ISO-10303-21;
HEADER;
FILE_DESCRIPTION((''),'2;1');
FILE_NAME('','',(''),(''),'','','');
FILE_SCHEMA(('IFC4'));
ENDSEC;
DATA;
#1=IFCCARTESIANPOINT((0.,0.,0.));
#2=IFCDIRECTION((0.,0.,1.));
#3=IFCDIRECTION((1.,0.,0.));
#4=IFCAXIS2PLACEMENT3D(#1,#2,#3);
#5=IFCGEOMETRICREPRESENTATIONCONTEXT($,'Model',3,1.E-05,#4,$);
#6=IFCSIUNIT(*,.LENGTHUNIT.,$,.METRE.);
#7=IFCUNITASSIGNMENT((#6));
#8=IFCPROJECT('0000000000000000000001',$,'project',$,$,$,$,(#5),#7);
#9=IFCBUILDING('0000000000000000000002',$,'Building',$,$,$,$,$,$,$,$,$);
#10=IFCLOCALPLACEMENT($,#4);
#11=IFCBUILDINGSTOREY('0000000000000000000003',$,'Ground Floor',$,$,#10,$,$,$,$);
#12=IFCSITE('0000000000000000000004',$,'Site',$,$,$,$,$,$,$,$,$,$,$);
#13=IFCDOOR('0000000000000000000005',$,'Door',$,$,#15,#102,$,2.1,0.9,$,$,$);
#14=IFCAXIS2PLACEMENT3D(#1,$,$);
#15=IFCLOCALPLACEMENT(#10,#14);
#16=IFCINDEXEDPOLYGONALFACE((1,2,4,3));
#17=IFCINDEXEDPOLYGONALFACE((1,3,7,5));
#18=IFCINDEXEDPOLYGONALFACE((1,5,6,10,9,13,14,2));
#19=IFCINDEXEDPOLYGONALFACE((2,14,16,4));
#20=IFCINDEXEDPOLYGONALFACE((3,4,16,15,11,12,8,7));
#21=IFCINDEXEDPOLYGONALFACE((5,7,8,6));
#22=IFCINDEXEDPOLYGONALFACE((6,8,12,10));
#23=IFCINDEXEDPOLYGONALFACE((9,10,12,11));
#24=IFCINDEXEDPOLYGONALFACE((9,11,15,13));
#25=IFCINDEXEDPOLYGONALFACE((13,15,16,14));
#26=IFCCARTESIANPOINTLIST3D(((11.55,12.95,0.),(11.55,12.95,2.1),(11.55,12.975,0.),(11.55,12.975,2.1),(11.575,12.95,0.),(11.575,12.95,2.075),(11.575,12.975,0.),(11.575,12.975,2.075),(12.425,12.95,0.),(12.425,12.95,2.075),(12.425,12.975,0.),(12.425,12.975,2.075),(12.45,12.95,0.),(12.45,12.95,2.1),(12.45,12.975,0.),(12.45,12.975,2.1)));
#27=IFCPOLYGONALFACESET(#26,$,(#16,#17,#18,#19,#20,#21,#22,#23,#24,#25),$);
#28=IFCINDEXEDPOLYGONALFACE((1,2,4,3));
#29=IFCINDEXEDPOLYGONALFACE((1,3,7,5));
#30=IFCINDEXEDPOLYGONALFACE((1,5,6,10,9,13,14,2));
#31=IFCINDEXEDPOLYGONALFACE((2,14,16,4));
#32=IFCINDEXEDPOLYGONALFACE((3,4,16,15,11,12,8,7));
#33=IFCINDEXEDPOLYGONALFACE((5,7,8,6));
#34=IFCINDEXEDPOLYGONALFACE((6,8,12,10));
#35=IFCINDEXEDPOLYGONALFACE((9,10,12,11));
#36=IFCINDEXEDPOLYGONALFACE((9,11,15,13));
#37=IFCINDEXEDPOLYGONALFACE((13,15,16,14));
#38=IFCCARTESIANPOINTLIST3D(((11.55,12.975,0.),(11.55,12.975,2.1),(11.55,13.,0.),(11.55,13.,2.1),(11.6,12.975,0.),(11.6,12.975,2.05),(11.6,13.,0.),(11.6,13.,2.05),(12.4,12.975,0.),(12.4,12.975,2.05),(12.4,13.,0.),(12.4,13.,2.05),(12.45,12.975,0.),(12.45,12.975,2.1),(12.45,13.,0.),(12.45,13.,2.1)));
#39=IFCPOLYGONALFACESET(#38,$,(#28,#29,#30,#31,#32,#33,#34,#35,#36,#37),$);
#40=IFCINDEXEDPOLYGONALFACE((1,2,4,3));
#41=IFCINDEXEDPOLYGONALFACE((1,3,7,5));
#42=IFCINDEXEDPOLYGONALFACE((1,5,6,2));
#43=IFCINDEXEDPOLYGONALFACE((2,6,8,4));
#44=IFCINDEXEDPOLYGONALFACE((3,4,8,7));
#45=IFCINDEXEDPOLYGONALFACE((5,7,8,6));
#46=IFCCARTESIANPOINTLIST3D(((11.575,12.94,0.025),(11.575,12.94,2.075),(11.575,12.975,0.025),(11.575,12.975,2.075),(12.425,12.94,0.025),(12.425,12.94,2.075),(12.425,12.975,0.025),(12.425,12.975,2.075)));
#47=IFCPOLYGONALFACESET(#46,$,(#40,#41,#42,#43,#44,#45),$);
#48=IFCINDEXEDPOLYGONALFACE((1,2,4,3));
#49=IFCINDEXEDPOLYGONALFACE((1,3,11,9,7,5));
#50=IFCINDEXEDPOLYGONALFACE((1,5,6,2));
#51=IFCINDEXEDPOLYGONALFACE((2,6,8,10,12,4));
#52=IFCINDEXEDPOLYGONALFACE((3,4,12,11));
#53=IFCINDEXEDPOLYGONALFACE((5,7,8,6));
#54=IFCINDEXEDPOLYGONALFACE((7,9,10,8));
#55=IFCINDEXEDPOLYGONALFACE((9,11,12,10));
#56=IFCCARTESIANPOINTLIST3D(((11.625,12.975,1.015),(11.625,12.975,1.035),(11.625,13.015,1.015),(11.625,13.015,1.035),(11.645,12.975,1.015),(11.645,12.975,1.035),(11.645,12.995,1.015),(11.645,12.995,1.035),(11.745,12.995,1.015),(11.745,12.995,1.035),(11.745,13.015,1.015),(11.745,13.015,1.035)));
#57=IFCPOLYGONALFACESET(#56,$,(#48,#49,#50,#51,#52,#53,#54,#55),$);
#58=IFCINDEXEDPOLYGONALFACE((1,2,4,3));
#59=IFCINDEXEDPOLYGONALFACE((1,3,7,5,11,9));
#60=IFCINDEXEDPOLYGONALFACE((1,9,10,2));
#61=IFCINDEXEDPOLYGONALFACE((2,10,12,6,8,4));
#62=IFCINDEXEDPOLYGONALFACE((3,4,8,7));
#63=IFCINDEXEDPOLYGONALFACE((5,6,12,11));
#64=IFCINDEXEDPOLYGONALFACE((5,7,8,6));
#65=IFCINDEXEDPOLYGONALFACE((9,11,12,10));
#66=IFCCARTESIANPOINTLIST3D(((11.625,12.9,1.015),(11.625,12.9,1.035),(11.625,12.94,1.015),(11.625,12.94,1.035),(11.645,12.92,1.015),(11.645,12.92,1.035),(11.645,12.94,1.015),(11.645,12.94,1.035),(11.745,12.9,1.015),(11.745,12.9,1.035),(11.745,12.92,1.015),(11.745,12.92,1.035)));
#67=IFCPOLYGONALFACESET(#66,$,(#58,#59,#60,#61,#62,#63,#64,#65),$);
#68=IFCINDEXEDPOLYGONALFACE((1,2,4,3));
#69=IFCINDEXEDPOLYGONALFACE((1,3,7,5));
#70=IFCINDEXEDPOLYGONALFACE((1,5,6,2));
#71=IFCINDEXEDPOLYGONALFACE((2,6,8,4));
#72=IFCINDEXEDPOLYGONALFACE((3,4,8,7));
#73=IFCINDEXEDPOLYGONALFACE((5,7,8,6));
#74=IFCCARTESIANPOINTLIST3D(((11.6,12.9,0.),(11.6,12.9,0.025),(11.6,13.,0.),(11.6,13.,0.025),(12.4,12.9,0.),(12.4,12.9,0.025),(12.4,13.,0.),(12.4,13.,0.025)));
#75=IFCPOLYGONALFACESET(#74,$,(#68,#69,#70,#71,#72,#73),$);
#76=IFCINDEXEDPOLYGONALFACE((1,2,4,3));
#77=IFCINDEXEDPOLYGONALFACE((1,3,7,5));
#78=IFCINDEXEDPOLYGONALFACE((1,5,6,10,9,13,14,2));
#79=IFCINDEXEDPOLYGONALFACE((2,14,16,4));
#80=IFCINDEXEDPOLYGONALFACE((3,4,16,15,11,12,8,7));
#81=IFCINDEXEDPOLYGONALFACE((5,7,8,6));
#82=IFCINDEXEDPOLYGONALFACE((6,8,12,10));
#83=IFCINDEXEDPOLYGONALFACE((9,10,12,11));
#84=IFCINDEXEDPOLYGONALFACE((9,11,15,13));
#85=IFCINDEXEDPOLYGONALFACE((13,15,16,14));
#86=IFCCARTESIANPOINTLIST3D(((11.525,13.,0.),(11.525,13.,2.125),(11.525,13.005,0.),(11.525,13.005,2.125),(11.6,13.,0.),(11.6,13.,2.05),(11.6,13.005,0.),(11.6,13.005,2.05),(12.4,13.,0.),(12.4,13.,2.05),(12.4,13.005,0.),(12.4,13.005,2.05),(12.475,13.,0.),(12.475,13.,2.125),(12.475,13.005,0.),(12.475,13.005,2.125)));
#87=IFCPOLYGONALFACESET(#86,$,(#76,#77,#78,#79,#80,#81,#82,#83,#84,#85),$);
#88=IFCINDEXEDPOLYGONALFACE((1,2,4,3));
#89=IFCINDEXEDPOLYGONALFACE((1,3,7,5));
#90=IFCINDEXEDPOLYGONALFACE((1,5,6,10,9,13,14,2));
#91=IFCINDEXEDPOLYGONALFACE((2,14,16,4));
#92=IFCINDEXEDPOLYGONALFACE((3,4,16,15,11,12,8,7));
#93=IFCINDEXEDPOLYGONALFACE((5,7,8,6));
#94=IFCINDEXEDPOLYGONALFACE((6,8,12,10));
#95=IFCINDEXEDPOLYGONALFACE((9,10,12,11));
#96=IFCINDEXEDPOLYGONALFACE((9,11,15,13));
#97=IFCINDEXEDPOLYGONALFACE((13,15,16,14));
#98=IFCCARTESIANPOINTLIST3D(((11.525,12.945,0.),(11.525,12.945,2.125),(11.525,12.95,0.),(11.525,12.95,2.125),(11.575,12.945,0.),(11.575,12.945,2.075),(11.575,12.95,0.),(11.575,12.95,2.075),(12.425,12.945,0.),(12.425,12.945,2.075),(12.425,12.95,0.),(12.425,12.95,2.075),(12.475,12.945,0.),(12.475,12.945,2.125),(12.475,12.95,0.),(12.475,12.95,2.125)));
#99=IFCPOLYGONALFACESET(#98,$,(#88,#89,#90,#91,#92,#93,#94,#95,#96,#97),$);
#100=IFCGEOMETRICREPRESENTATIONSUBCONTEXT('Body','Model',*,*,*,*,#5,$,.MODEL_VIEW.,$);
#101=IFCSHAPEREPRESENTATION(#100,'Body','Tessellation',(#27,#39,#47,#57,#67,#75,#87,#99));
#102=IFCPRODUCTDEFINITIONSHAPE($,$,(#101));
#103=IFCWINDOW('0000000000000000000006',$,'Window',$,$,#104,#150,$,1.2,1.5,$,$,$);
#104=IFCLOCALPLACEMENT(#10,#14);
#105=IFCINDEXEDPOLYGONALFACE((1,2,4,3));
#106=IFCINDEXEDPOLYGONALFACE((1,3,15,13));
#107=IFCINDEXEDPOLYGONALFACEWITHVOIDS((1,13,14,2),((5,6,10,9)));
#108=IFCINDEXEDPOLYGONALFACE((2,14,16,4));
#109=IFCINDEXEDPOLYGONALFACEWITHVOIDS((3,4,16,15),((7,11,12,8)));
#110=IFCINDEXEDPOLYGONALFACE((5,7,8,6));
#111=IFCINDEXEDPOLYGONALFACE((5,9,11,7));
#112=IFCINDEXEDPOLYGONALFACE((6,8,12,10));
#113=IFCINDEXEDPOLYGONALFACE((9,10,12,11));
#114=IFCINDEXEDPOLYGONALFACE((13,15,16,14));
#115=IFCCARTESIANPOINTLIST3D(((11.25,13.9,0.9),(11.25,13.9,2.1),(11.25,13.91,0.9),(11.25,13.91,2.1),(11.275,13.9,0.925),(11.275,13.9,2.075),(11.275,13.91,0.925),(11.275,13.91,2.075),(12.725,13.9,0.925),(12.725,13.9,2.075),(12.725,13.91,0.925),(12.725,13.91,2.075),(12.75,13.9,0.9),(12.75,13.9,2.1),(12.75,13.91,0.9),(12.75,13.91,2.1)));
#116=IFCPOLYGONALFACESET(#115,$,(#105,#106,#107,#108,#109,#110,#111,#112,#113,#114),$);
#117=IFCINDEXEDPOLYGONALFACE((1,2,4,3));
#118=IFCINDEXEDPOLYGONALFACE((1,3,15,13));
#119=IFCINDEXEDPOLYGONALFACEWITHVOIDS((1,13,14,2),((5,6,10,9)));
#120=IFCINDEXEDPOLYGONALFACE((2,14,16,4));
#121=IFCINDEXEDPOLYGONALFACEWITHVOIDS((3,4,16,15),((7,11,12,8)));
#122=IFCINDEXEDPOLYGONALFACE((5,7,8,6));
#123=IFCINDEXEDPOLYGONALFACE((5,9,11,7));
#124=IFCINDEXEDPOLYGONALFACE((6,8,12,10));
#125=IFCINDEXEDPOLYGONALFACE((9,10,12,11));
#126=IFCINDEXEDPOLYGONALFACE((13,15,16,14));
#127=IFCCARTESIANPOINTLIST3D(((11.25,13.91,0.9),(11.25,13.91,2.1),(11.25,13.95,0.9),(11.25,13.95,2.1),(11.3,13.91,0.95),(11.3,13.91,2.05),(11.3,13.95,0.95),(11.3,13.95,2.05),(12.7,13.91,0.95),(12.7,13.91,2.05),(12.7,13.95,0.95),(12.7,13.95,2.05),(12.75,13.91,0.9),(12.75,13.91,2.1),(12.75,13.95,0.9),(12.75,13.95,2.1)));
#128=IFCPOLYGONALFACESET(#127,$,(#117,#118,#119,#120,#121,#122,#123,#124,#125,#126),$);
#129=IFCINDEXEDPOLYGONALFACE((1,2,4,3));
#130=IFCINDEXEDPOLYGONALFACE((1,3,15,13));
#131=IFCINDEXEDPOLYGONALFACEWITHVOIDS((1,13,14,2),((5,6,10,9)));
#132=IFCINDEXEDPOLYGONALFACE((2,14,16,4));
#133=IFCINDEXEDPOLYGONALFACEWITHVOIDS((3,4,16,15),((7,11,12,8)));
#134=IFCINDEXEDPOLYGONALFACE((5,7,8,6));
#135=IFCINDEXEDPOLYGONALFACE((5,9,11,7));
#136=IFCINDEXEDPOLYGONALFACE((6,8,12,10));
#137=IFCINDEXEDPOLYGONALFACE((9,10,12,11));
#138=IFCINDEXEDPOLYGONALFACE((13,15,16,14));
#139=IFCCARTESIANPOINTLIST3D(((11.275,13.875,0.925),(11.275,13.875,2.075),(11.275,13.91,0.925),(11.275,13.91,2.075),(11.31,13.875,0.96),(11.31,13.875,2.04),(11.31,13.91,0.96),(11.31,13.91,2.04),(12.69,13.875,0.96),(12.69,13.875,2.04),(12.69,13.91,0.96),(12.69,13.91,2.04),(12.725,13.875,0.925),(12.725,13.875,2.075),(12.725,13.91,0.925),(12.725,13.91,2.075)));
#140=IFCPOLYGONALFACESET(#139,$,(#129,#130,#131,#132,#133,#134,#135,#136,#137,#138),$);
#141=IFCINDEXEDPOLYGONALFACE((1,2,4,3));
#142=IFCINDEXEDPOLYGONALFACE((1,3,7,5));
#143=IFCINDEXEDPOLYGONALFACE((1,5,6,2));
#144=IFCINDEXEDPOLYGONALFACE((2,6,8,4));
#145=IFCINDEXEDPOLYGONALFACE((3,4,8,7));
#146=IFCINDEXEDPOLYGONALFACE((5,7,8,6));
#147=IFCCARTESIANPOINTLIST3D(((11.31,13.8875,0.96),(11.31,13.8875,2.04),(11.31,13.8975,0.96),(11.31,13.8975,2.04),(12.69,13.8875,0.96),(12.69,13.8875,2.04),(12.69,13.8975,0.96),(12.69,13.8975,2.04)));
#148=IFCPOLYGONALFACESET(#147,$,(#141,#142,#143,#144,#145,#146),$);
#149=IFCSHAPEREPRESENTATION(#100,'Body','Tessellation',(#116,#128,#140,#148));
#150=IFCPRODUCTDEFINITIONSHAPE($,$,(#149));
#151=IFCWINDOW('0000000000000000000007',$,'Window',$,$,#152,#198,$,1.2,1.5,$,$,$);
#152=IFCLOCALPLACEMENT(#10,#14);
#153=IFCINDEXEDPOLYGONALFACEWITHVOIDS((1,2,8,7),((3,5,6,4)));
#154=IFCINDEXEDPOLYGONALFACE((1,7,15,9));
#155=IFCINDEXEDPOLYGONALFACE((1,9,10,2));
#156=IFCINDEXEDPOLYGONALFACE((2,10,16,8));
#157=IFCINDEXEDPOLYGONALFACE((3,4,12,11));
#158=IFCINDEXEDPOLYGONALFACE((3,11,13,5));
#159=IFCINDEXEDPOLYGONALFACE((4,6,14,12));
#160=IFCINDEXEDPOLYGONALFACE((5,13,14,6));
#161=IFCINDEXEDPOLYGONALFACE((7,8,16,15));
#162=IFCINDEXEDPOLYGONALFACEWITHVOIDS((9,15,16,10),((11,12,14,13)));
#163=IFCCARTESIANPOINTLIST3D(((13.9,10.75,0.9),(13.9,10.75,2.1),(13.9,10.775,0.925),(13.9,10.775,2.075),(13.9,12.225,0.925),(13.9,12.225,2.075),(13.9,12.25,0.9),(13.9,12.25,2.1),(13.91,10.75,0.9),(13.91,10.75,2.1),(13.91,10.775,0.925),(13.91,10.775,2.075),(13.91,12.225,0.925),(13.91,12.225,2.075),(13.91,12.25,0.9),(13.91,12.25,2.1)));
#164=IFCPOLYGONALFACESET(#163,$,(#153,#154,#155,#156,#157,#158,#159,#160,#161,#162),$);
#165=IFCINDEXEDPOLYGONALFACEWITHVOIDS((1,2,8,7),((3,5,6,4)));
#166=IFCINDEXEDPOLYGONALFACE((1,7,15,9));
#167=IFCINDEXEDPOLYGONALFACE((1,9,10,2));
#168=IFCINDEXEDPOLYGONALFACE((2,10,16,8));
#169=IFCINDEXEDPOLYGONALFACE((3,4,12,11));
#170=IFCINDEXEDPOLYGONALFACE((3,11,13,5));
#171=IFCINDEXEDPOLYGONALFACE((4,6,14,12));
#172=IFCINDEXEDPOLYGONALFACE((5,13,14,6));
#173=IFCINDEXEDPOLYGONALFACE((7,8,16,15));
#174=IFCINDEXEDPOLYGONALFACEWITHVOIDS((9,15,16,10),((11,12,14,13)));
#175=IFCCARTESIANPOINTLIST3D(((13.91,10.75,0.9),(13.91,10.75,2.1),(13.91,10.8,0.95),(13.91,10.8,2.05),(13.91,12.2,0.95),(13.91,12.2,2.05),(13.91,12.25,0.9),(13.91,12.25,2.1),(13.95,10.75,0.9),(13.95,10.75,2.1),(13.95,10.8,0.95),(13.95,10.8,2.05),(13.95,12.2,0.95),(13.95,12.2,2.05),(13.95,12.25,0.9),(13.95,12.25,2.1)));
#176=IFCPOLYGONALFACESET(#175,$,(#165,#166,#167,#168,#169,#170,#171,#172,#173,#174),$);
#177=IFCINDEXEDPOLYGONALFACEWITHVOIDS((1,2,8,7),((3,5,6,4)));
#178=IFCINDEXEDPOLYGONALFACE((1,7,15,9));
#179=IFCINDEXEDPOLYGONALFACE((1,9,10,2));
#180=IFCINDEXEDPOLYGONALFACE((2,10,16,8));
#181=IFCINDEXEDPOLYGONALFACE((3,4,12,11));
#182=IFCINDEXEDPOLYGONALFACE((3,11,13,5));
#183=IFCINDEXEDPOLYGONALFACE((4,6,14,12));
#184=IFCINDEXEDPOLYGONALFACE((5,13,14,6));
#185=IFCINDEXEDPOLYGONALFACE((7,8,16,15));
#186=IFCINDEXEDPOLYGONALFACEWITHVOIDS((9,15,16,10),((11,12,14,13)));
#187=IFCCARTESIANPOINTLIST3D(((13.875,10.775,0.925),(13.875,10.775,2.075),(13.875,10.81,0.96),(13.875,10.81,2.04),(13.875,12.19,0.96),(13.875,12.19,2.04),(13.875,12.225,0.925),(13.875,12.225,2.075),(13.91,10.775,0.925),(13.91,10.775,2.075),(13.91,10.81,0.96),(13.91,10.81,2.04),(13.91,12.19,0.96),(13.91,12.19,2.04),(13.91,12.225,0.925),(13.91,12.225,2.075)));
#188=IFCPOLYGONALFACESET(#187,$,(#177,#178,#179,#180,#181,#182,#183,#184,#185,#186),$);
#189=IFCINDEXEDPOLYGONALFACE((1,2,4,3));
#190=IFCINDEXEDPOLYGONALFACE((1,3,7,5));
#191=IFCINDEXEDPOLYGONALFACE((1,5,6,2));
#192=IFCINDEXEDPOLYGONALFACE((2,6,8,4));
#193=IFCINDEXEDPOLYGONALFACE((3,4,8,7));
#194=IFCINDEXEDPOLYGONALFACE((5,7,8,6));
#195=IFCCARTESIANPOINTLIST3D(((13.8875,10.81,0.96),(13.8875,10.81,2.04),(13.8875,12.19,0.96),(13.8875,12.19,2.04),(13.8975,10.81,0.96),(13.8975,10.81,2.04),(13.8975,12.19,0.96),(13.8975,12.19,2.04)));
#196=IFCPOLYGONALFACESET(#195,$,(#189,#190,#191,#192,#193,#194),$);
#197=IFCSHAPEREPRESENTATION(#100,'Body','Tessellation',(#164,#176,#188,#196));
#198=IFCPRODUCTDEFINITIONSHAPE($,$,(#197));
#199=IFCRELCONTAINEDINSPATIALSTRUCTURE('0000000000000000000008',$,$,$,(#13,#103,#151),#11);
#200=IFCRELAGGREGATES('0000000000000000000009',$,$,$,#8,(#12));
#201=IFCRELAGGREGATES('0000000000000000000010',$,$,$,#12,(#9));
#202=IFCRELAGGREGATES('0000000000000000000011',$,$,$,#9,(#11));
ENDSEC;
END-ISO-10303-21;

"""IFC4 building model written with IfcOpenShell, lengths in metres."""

from ifc_helpers import new_model, si_unit, frame, origin_with_axes, place, context, subcontext, project, spatial, line, indexed_curve, outline, extrude, element, save


model = new_model("IFC4")

# Units and contexts
model_context = context("Model", 3, precision=1e-05, world=origin_with_axes())
body_context = subcontext(model_context, "Body", "Model", "MODEL_VIEW")
ifc_project = project(units=[si_unit("LENGTHUNIT", "METRE")], contexts=[model_context])

# Site, building, storey
site = spatial("IfcSite", under=ifc_project, Name="Site")
building = spatial("IfcBuilding", under=site, Name="Building")
storey_placement = place(None, origin_with_axes())
storey = spatial("IfcBuildingStorey", under=building, at=storey_placement, Name="Ground Floor")

# Door
door_1_placement = place(storey_placement, frame((12.45, 13.0, 0.0), z_axis=(0.0, 0.0, 1.0), x_axis=(-1.0, 0.0, 0.0)))
element("IfcDoor", 1, at=door_1_placement, inside=storey, Name="Door", OverallHeight=2.1, OverallWidth=0.9, context=body_context, shape_type="SweptSolid", body=[
    extrude(outline(indexed_curve([(0.0, 0.0), (0.0, 2.1), (0.9, 2.1), (0.9, 0.0), (0.875, 0.0), (0.875, 2.075), (0.025, 2.075), (0.025, 0.0)], segments=[line(1, 2, 3, 4, 5, 6, 7, 8, 1)])), frame((0.0, 0.025, 0.0), z_axis=(0.0, -1.0, 0.0), x_axis=(1.0, 0.0, 0.0)), (0.0, 0.0, -1.0), 0.025),
    extrude(outline(indexed_curve([(0.0, 0.0), (0.0, 2.1), (0.9, 2.1), (0.9, 0.0), (0.85, 0.0), (0.85, 2.05), (0.05, 2.05), (0.05, 0.0)], segments=[line(1, 2, 3, 4, 5, 6, 7, 8, 1)])), frame((0.0, 0.0, 0.0), z_axis=(0.0, -1.0, 0.0), x_axis=(1.0, 0.0, 0.0)), (0.0, 0.0, -1.0), 0.025),
    extrude(outline(indexed_curve([(0.0, 0.0), (0.85, 0.0), (0.85, 0.035), (0.0, 0.035)], segments=[line(1, 2, 3, 4, 1)])), frame((0.025, 0.025, 0.025), z_axis=(0.0, 0.0, 1.0), x_axis=(1.0, 0.0, 0.0)), (0.0, 0.0, 1.0), 2.05),
    extrude(outline(indexed_curve([(0.0, 0.0), (0.0, -0.04), (-0.12, -0.04), (-0.12, -0.02), (-0.02, -0.02), (-0.02, 0.0)], segments=[line(1, 2, 3, 4, 5, 6, 1)])), frame((0.825, 0.025, 1.015), z_axis=(0.0, 0.0, 1.0), x_axis=(1.0, 0.0, 0.0)), (0.0, 0.0, 1.0), 0.02),
    extrude(outline(indexed_curve([(0.0, 0.0), (0.0, 0.04), (-0.12, 0.04), (-0.12, 0.02), (-0.02, 0.02), (-0.02, 0.0)], segments=[line(1, 2, 3, 4, 5, 6, 1)])), frame((0.825, 0.06, 1.015), z_axis=(0.0, 0.0, 1.0), x_axis=(1.0, 0.0, 0.0)), (0.0, 0.0, 1.0), 0.02),
    extrude(outline(indexed_curve([(0.0, 0.0), (0.8, 0.0), (0.8, 0.1), (0.0, 0.1)], segments=[line(1, 2, 3, 4, 1)])), frame((0.05, 0.0, 0.0), z_axis=(0.0, 0.0, 1.0), x_axis=(1.0, 0.0, 0.0)), (0.0, 0.0, 1.0), 0.025),
    extrude(outline(indexed_curve([(0.0, 0.0), (0.0, 2.125), (0.95, 2.125), (0.95, 0.0), (0.875, 0.0), (0.875, 2.05), (0.075, 2.05), (0.075, 0.0)], segments=[line(1, 2, 3, 4, 5, 6, 7, 8, 1)])), frame((-0.025, -0.005, 0.0), z_axis=(0.0, -1.0, 0.0), x_axis=(1.0, 0.0, 0.0)), (0.0, 0.0, -1.0), 0.005),
    extrude(outline(indexed_curve([(0.0, 0.0), (0.0, 2.125), (0.95, 2.125), (0.95, 0.0), (0.9, 0.0), (0.9, 2.075), (0.05, 2.075), (0.05, 0.0)], segments=[line(1, 2, 3, 4, 5, 6, 7, 8, 1)])), frame((-0.025, 0.05, 0.0), z_axis=(0.0, -1.0, 0.0), x_axis=(1.0, 0.0, 0.0)), (0.0, 0.0, -1.0), 0.005),
])

# Windows
for number, where, z_axis, x_axis, name in (
    (2, (12.75, 14.0, 0.9), (0.0, 0.0, 1.0), (-1.0, 0.0, 0.0), "Window"),
    (3, (14.0, 10.75, 0.9), (0.0, 0.0, 1.0), (0.0, 1.0, 0.0), "Window"),
):
    element("IfcWindow", number, at=place(storey_placement, frame(where, z_axis=z_axis, x_axis=x_axis)), inside=storey, Name=name, OverallHeight=1.2, OverallWidth=1.5, context=body_context, shape_type="SweptSolid", body=[
        extrude(outline(indexed_curve([(0.0, 0.0), (1.5, 0.0), (1.5, 1.2), (0.0, 1.2)], segments=[line(1, 2, 3, 4, 1)]), holes=[indexed_curve([(0.025, 0.025), (1.475, 0.025), (1.475, 1.175), (0.025, 1.175)], segments=[line(1, 2, 3, 4, 1)])]), frame((0.0, 0.09, 0.0), z_axis=(0.0, -1.0, 0.0), x_axis=(1.0, 0.0, 0.0)), (0.0, 0.0, -1.0), 0.01),
        extrude(outline(indexed_curve([(0.0, 0.0), (1.5, 0.0), (1.5, 1.2), (0.0, 1.2)], segments=[line(1, 2, 3, 4, 1)]), holes=[indexed_curve([(0.05, 0.05), (1.45, 0.05), (1.45, 1.15), (0.05, 1.15)], segments=[line(1, 2, 3, 4, 1)])]), frame((0.0, 0.05, 0.0), z_axis=(0.0, -1.0, 0.0), x_axis=(1.0, 0.0, 0.0)), (0.0, 0.0, -1.0), 0.04),
        extrude(outline(indexed_curve([(0.0, 0.0), (1.45, 0.0), (1.45, 1.15), (0.0, 1.15)], segments=[line(1, 2, 3, 4, 1)]), holes=[indexed_curve([(0.035, 0.035), (1.415, 0.035), (1.415, 1.115), (0.035, 1.115)], segments=[line(1, 2, 3, 4, 1)])]), frame((0.025, 0.09, 0.025), z_axis=(0.0, -1.0, 0.0), x_axis=(1.0, 0.0, 0.0)), (0.0, 0.0, -1.0), 0.035),
        extrude(outline(indexed_curve([(0.035, 0.035), (1.415, 0.035), (1.415, 1.115), (0.035, 1.115)], segments=[line(1, 2, 3, 4, 1)])), frame((0.025, 0.1025, 0.025), z_axis=(0.0, -1.0, 0.0), x_axis=(1.0, 0.0, 0.0)), (0.0, 0.0, -1.0), 0.01),
    ])

save(model, "model.ifc")
